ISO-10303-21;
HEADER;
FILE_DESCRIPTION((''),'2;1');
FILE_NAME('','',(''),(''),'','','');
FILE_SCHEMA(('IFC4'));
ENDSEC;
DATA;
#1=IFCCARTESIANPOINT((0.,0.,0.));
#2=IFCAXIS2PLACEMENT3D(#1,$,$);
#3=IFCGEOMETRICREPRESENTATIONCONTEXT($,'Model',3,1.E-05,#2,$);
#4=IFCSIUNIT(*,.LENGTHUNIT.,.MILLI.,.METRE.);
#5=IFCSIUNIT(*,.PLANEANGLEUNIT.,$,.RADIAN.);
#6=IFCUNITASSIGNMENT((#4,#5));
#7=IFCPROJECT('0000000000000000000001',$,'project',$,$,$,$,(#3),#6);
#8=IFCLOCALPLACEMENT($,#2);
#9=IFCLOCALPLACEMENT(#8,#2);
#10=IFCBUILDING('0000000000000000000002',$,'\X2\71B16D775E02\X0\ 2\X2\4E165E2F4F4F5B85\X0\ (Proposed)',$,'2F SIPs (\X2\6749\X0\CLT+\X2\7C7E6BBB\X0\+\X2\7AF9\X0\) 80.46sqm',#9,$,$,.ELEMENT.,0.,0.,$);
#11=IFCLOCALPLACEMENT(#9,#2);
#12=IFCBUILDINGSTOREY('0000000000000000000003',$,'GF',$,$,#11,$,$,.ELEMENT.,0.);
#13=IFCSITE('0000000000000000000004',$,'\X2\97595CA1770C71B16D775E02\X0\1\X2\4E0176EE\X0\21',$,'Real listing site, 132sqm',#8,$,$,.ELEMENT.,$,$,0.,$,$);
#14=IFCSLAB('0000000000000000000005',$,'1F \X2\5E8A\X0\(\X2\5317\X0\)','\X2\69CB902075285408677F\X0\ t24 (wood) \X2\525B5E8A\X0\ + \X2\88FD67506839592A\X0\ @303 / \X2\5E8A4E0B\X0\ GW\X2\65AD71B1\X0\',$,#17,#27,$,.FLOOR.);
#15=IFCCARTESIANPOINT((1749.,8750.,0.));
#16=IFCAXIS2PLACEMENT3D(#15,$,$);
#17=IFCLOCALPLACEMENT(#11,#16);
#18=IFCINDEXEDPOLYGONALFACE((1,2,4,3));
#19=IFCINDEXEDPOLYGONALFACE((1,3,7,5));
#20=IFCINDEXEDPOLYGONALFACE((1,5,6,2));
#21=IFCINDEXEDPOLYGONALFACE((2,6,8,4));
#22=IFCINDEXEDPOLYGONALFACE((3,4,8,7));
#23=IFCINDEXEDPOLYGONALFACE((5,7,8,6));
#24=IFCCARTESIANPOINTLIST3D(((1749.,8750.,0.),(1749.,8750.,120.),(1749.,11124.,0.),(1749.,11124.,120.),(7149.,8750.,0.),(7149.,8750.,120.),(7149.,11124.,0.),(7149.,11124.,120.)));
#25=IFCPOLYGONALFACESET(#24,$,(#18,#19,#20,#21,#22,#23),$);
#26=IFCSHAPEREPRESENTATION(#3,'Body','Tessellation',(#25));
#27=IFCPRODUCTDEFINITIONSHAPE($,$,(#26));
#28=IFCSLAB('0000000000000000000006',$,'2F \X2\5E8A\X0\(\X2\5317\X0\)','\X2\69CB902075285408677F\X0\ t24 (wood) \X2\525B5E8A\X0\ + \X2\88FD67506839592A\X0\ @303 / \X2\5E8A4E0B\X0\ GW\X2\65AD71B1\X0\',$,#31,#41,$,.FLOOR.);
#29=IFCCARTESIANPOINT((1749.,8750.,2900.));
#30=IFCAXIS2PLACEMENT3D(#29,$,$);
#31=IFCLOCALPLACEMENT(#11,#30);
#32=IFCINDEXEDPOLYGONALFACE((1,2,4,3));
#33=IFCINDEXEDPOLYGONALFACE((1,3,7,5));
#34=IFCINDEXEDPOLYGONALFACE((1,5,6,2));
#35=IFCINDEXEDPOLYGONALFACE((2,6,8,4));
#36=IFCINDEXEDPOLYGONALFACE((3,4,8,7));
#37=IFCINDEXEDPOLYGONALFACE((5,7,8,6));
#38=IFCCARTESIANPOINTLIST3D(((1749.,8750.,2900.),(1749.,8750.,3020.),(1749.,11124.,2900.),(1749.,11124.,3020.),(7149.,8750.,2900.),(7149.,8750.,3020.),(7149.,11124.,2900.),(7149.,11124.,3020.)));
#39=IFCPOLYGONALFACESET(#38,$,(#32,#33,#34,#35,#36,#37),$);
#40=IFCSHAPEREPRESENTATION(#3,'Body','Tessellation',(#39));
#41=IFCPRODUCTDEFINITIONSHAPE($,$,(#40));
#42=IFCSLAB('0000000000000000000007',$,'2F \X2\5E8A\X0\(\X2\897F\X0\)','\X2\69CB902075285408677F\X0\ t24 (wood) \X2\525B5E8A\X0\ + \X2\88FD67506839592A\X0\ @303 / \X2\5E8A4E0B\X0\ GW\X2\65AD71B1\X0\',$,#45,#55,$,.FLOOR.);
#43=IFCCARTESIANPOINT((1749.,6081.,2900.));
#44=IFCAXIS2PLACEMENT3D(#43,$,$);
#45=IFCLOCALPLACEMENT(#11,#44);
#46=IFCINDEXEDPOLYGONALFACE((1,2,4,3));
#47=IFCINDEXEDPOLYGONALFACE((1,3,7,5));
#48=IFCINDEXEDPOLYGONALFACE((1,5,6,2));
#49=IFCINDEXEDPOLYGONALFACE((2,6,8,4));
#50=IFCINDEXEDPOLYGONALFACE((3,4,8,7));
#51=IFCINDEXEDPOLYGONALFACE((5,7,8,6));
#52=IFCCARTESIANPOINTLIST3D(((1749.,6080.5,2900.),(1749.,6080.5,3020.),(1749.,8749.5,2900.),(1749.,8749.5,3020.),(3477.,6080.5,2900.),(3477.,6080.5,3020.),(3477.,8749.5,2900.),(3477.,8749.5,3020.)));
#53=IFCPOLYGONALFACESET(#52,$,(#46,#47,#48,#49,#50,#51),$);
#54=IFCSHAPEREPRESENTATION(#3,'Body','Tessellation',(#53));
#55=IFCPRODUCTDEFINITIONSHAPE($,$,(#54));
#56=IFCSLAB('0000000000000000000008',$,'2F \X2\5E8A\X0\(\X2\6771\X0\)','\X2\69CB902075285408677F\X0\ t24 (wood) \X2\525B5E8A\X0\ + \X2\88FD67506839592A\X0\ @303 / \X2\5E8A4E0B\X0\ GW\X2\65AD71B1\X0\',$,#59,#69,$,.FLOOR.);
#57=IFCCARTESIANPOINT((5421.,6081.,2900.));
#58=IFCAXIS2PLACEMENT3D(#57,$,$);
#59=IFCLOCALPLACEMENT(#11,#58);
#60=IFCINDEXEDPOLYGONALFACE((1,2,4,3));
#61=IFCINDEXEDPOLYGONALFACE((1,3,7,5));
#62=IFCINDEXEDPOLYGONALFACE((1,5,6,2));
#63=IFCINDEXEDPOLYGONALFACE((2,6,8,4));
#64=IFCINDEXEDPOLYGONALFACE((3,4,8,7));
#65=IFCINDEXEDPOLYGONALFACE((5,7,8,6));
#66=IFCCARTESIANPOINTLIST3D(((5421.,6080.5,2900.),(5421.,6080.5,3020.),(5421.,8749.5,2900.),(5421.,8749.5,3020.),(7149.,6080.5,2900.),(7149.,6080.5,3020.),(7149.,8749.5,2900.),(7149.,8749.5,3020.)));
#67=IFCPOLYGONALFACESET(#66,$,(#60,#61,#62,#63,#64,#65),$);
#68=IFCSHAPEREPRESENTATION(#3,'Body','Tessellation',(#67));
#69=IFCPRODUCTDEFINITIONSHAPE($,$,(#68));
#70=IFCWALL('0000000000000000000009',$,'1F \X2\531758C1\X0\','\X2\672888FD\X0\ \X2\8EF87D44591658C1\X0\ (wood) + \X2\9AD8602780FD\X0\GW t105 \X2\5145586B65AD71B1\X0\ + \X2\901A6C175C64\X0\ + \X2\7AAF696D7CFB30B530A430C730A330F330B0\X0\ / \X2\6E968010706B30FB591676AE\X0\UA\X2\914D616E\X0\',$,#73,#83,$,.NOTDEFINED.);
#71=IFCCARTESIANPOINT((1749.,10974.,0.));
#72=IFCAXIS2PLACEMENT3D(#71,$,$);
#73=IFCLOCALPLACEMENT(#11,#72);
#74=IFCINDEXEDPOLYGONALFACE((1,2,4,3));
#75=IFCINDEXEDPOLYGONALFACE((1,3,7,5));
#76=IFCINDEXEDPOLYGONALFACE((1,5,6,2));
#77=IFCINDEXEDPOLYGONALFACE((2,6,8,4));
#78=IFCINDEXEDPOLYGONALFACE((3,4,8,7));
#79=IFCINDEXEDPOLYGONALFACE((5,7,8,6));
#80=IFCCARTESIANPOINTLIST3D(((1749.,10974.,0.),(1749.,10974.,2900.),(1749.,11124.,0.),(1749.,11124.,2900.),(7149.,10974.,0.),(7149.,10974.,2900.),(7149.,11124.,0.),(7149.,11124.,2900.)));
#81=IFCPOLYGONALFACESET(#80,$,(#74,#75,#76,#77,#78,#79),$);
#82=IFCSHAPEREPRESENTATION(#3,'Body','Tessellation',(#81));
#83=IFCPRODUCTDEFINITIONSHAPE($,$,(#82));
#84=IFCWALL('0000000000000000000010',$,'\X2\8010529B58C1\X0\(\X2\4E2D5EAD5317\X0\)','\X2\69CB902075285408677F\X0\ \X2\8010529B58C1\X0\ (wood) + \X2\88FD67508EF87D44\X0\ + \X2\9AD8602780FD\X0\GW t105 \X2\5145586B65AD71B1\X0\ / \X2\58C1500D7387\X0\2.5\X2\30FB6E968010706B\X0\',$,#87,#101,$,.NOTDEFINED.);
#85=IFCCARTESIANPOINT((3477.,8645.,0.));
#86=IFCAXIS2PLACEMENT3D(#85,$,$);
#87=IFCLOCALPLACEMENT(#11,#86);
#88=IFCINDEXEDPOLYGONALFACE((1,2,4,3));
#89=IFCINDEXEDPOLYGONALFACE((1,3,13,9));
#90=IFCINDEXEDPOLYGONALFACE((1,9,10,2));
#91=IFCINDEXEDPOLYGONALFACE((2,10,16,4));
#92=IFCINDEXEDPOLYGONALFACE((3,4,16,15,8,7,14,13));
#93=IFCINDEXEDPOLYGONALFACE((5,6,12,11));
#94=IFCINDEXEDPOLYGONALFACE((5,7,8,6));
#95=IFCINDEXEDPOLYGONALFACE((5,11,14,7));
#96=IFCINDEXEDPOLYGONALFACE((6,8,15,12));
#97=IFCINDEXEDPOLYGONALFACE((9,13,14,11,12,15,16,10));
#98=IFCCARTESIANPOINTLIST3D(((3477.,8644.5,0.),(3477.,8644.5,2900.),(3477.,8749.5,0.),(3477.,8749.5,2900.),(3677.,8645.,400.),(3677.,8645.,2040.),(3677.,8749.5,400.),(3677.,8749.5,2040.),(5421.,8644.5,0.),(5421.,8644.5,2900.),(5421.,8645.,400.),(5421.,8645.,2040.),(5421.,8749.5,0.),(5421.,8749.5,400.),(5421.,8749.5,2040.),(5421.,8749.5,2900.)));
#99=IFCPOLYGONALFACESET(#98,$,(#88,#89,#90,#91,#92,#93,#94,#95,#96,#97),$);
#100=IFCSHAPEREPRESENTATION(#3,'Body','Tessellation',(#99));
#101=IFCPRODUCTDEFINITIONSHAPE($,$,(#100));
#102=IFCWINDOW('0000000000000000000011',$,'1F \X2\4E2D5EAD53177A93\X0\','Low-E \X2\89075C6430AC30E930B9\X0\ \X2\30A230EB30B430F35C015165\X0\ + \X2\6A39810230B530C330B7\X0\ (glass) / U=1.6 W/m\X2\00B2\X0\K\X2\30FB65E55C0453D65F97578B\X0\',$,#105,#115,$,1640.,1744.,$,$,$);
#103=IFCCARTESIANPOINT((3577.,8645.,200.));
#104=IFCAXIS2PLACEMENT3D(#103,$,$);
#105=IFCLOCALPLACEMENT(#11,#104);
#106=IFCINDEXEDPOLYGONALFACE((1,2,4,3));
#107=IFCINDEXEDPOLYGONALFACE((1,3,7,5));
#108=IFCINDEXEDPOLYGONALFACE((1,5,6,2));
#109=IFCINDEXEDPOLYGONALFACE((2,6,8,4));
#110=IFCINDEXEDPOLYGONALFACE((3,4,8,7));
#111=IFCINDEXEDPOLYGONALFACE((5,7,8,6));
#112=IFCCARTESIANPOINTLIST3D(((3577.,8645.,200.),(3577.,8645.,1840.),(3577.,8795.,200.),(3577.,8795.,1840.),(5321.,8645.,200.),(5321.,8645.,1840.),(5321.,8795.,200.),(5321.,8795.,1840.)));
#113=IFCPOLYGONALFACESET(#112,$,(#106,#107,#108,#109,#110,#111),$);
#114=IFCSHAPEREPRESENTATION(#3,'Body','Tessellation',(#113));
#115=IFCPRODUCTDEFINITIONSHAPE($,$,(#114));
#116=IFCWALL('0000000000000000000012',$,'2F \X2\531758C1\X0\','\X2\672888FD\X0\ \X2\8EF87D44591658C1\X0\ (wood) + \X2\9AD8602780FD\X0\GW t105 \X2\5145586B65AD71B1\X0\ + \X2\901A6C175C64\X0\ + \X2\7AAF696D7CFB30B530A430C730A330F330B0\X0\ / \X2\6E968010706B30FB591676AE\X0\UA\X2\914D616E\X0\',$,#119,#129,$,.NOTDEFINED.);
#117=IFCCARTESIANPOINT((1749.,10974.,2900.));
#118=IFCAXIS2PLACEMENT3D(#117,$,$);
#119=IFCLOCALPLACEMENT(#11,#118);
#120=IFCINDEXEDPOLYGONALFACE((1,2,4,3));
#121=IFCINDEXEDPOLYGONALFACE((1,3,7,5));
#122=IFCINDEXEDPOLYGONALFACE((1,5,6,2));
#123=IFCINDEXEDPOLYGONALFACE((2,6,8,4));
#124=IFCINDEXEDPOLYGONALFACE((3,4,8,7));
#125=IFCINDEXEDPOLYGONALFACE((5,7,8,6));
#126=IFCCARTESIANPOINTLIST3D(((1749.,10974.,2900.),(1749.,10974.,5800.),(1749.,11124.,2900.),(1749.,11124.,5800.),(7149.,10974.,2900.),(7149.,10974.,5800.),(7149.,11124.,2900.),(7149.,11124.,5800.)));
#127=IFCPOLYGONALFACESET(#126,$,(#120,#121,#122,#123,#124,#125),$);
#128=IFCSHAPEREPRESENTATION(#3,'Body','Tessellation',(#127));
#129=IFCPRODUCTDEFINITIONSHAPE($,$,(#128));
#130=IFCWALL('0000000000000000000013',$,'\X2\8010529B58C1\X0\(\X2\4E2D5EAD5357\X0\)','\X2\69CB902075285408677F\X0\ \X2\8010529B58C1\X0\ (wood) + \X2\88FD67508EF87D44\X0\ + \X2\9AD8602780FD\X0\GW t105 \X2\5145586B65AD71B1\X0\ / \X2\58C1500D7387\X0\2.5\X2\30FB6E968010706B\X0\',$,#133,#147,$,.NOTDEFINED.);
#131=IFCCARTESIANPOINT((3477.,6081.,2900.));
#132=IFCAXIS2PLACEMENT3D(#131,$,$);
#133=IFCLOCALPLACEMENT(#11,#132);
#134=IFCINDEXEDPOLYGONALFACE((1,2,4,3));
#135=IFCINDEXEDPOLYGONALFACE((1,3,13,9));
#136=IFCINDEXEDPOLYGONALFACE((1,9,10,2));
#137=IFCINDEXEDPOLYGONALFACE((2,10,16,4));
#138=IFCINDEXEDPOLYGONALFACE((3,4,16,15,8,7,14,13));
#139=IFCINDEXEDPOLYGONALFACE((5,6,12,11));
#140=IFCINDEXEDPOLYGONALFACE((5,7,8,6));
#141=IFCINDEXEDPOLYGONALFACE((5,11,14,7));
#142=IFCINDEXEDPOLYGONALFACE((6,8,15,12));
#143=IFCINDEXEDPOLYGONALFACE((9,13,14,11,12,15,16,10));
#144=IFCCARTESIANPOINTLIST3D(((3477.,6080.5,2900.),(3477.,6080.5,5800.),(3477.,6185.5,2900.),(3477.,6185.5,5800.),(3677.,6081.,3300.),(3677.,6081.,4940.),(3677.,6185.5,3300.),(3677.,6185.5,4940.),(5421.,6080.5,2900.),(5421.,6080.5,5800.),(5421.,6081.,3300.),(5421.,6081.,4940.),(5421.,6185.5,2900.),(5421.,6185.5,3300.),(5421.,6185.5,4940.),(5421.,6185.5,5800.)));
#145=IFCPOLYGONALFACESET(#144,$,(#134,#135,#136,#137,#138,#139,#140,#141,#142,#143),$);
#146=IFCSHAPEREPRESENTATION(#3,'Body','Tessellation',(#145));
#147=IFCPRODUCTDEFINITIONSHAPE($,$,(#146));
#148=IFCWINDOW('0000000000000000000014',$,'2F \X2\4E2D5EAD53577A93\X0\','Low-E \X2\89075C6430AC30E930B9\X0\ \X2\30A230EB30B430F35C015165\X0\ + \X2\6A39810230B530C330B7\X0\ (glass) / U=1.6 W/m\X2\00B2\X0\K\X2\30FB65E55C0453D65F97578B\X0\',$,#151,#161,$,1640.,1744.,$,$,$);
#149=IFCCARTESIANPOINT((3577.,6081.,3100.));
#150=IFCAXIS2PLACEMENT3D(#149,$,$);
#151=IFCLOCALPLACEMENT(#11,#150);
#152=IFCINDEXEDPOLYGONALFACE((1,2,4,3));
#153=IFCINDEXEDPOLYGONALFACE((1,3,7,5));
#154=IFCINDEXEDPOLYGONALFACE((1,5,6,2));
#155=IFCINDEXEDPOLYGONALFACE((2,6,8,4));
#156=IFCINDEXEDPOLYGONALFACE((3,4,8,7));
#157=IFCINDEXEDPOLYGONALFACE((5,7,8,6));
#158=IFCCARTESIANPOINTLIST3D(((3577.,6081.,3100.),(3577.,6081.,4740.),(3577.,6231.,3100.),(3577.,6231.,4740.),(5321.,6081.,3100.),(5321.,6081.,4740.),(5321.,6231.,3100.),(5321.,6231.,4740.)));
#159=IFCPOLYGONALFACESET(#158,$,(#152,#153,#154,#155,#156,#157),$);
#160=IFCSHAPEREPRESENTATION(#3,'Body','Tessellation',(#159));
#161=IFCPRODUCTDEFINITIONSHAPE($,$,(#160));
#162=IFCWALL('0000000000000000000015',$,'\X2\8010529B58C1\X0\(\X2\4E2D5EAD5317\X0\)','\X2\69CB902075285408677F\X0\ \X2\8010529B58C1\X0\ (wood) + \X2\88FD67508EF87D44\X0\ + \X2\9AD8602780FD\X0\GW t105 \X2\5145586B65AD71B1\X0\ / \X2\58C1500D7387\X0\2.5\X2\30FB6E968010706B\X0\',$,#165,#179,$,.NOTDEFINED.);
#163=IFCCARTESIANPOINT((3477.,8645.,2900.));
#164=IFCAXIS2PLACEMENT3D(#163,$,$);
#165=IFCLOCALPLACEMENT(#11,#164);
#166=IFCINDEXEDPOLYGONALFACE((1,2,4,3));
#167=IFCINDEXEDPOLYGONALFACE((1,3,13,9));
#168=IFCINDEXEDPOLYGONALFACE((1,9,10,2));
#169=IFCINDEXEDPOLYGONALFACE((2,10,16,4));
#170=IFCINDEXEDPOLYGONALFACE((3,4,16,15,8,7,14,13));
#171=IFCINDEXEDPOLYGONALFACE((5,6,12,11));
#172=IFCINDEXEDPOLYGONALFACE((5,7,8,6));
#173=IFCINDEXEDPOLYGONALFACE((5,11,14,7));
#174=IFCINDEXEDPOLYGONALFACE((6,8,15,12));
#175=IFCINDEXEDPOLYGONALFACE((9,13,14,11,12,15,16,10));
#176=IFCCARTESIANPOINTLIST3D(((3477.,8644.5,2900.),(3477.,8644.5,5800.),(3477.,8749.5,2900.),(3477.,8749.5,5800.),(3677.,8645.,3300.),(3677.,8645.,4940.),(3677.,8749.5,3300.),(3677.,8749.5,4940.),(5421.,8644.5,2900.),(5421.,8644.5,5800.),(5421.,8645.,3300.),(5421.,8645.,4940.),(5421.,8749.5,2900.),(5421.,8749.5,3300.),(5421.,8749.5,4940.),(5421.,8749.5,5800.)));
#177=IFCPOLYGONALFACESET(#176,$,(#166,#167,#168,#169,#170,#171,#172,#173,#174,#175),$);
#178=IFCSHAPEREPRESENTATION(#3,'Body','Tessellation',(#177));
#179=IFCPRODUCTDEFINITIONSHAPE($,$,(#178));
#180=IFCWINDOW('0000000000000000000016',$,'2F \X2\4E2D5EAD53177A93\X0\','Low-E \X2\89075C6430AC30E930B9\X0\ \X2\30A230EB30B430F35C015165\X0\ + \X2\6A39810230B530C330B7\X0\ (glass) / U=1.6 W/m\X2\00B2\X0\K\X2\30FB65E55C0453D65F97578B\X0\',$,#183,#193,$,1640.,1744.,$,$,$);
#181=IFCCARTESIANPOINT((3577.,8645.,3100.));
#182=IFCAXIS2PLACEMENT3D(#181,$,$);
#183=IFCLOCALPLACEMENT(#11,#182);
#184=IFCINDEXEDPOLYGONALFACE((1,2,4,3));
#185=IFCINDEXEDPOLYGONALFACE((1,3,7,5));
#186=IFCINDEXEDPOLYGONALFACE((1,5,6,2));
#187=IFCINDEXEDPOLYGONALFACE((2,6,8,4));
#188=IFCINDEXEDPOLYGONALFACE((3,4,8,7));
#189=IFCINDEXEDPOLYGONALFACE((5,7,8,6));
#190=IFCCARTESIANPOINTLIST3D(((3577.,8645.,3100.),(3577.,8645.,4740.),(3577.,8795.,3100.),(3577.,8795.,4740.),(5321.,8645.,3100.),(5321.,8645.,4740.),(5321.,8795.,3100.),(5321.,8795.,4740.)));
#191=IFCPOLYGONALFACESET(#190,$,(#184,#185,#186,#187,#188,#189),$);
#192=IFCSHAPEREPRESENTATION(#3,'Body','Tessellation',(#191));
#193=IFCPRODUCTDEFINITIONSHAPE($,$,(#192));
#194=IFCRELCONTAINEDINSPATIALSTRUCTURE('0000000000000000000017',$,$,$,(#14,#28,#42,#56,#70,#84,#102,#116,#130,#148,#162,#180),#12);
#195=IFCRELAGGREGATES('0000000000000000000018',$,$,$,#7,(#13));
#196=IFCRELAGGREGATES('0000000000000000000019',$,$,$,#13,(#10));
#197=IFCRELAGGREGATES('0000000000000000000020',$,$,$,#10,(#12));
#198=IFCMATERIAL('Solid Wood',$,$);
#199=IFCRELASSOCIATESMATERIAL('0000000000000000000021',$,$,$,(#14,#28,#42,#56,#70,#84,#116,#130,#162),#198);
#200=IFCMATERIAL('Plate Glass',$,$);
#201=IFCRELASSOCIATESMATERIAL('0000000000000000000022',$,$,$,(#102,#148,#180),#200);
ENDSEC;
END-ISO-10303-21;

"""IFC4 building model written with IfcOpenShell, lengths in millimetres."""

from ifc_helpers import new_model, si_unit, frame, frame_2d, origin, place, context, project, spatial, rectangle, extrude, material, element, fill, save


model = new_model("IFC4")

# Units and contexts
model_context = context("Model", 3, precision=1e-05, world=origin())
ifc_project = project(units=[si_unit("LENGTHUNIT", "METRE", prefix="MILLI"), si_unit("PLANEANGLEUNIT", "RADIAN")], contexts=[model_context])

# Site, building, storey
site_placement = place(None, origin())
site = spatial("IfcSite", under=ifc_project, at=site_placement, Name="静岡県熱海市1丁目21", ObjectType="Real listing site, 132sqm", CompositionType="ELEMENT", RefElevation=0.0)
building_placement = place(site_placement, origin())
building = spatial("IfcBuilding", under=site, at=building_placement, Name="熱海市 2世帯住宅 (Proposed)", ObjectType="2F SIPs (杉CLT+籾殻+竹) 80.46sqm", CompositionType="ELEMENT", ElevationOfRefHeight=0.0, ElevationOfTerrain=0.0)
storey_placement = place(building_placement, origin())
storey = spatial("IfcBuildingStorey", under=building, at=storey_placement, Name="GF", CompositionType="ELEMENT", Elevation=0.0)

# Slabs
ifc_material_1 = material(Name="Solid Wood")
slab_1_placement = place(storey_placement, frame((1749.0, 8750.0, 0.0)))
element("IfcSlab", 1, at=slab_1_placement, inside=storey, material=ifc_material_1, Name="1F 床(北)", Description="構造用合板 t24 (wood) 剛床 + 製材根太 @303 / 床下 GW断熱", PredefinedType="FLOOR", context=model_context, shape_type="SweptSolid", body=[
    extrude(rectangle(XDim=5400.0, YDim=2374.0, at=frame_2d((2700.0, 1187.0))), frame((1749.0, 8750.0, 0.0)), (0.0, 0.0, 1.0), 120.0),
])
slab_2_placement = place(storey_placement, frame((1749.0, 8750.0, 2900.0)))
element("IfcSlab", 2, at=slab_2_placement, inside=storey, material=ifc_material_1, Name="2F 床(北)", Description="構造用合板 t24 (wood) 剛床 + 製材根太 @303 / 床下 GW断熱", PredefinedType="FLOOR", context=model_context, shape_type="SweptSolid", body=[
    extrude(rectangle(XDim=5400.0, YDim=2374.0, at=frame_2d((2700.0, 1187.0))), frame((1749.0, 8750.0, 2900.0)), (0.0, 0.0, 1.0), 120.0),
])
slab_3_placement = place(storey_placement, frame((1749.0, 6081.0, 2900.0)))
element("IfcSlab", 3, at=slab_3_placement, inside=storey, material=ifc_material_1, Name="2F 床(西)", Description="構造用合板 t24 (wood) 剛床 + 製材根太 @303 / 床下 GW断熱", PredefinedType="FLOOR", context=model_context, shape_type="SweptSolid", body=[
    extrude(rectangle(XDim=1728.0, YDim=2669.0, at=frame_2d((864.0, 1334.0))), frame((1749.0, 6081.0, 2900.0)), (0.0, 0.0, 1.0), 120.0),
])
slab_4_placement = place(storey_placement, frame((5421.0, 6081.0, 2900.0)))
element("IfcSlab", 4, at=slab_4_placement, inside=storey, material=ifc_material_1, Name="2F 床(東)", Description="構造用合板 t24 (wood) 剛床 + 製材根太 @303 / 床下 GW断熱", PredefinedType="FLOOR", context=model_context, shape_type="SweptSolid", body=[
    extrude(rectangle(XDim=1728.0, YDim=2669.0, at=frame_2d((864.0, 1334.0))), frame((5421.0, 6081.0, 2900.0)), (0.0, 0.0, 1.0), 120.0),
])

# Wall
wall_1_placement = place(storey_placement, frame((1749.0, 10974.0, 0.0)))
element("IfcWall", 5, at=wall_1_placement, inside=storey, material=ifc_material_1, Name="1F 北壁", Description="木製 軸組外壁 (wood) + 高性能GW t105 充填断熱 + 通気層 + 窯業系サイディング / 準耐火・外皮UA配慮", PredefinedType="NOTDEFINED", context=model_context, shape_type="SweptSolid", body=[
    extrude(rectangle(XDim=5400.0, YDim=150.0, at=frame_2d((2700.0, 75.0))), frame((1749.0, 10974.0, 0.0)), (0.0, 0.0, 1.0), 2900.0),
])

# Wall, opening, window
wall_2_placement = place(storey_placement, frame((3477.0, 8645.0, 0.0)))
wall_2 = element("IfcWall", 6, at=wall_2_placement, inside=storey, material=ifc_material_1, Name="耐力壁(中庭北)", Description="構造用合板 耐力壁 (wood) + 製材軸組 + 高性能GW t105 充填断熱 / 壁倍率2.5・準耐火", PredefinedType="NOTDEFINED", context=model_context, shape_type="SweptSolid", body=[
    extrude(rectangle(XDim=1944.0, YDim=105.0, at=frame_2d((972.0, 52.0))), frame((3477.0, 8645.0, 0.0)), (0.0, 0.0, 1.0), 2900.0),
])
opening_1_placement = place(storey_placement, frame((3577.0, 8645.0, 200.0)))
opening_1 = element("IfcOpeningElement", 7, at=opening_1_placement, cuts=wall_2, PredefinedType="NOTDEFINED", context=model_context, shape_type="SweptSolid", body=[
    extrude(rectangle(XDim=1744.0, YDim=150.0, at=frame_2d((872.0, 75.0))), frame((3577.0, 8645.0, 200.0)), (0.0, 0.0, 1.0), 1640.0),
])
ifc_material_2 = material(Name="Plate Glass")
window_1_placement = place(storey_placement, frame((3577.0, 8645.0, 200.0)))
window_1 = element("IfcWindow", 8, at=window_1_placement, inside=storey, material=ifc_material_2, Name="1F 中庭北窓", Description="Low-E 複層ガラス アルゴン封入 + 樹脂サッシ (glass) / U=1.6 W/m²K・日射取得型", OverallHeight=1640.0, OverallWidth=1744.0, context=model_context, shape_type="SweptSolid", body=[
    extrude(rectangle(XDim=1744.0, YDim=150.0, at=frame_2d((872.0, 75.0))), frame((3577.0, 8645.0, 200.0)), (0.0, 0.0, 1.0), 1640.0),
])
fill(opening_1, window_1)

# Wall
wall_3_placement = place(storey_placement, frame((1749.0, 10974.0, 2900.0)))
element("IfcWall", 9, at=wall_3_placement, inside=storey, material=ifc_material_1, Name="2F 北壁", Description="木製 軸組外壁 (wood) + 高性能GW t105 充填断熱 + 通気層 + 窯業系サイディング / 準耐火・外皮UA配慮", PredefinedType="NOTDEFINED", context=model_context, shape_type="SweptSolid", body=[
    extrude(rectangle(XDim=5400.0, YDim=150.0, at=frame_2d((2700.0, 75.0))), frame((1749.0, 10974.0, 2900.0)), (0.0, 0.0, 1.0), 2900.0),
])

# Walls, openings, windows
wall_4_placement = place(storey_placement, frame((3477.0, 6081.0, 2900.0)))
wall_4 = element("IfcWall", 10, at=wall_4_placement, inside=storey, material=ifc_material_1, Name="耐力壁(中庭南)", Description="構造用合板 耐力壁 (wood) + 製材軸組 + 高性能GW t105 充填断熱 / 壁倍率2.5・準耐火", PredefinedType="NOTDEFINED", context=model_context, shape_type="SweptSolid", body=[
    extrude(rectangle(XDim=1944.0, YDim=105.0, at=frame_2d((972.0, 52.0))), frame((3477.0, 6081.0, 2900.0)), (0.0, 0.0, 1.0), 2900.0),
])
opening_2_placement = place(storey_placement, frame((3577.0, 6081.0, 3100.0)))
opening_2 = element("IfcOpeningElement", 11, at=opening_2_placement, cuts=wall_4, PredefinedType="NOTDEFINED", context=model_context, shape_type="SweptSolid", body=[
    extrude(rectangle(XDim=1744.0, YDim=150.0, at=frame_2d((872.0, 75.0))), frame((3577.0, 6081.0, 3100.0)), (0.0, 0.0, 1.0), 1640.0),
])
window_2_placement = place(storey_placement, frame((3577.0, 6081.0, 3100.0)))
window_2 = element("IfcWindow", 12, at=window_2_placement, inside=storey, material=ifc_material_2, Name="2F 中庭南窓", Description="Low-E 複層ガラス アルゴン封入 + 樹脂サッシ (glass) / U=1.6 W/m²K・日射取得型", OverallHeight=1640.0, OverallWidth=1744.0, context=model_context, shape_type="SweptSolid", body=[
    extrude(rectangle(XDim=1744.0, YDim=150.0, at=frame_2d((872.0, 75.0))), frame((3577.0, 6081.0, 3100.0)), (0.0, 0.0, 1.0), 1640.0),
])
fill(opening_2, window_2)
wall_5_placement = place(storey_placement, frame((3477.0, 8645.0, 2900.0)))
wall_5 = element("IfcWall", 13, at=wall_5_placement, inside=storey, material=ifc_material_1, Name="耐力壁(中庭北)", Description="構造用合板 耐力壁 (wood) + 製材軸組 + 高性能GW t105 充填断熱 / 壁倍率2.5・準耐火", PredefinedType="NOTDEFINED", context=model_context, shape_type="SweptSolid", body=[
    extrude(rectangle(XDim=1944.0, YDim=105.0, at=frame_2d((972.0, 52.0))), frame((3477.0, 8645.0, 2900.0)), (0.0, 0.0, 1.0), 2900.0),
])
opening_3_placement = place(storey_placement, frame((3577.0, 8645.0, 3100.0)))
opening_3 = element("IfcOpeningElement", 14, at=opening_3_placement, cuts=wall_5, PredefinedType="NOTDEFINED", context=model_context, shape_type="SweptSolid", body=[
    extrude(rectangle(XDim=1744.0, YDim=150.0, at=frame_2d((872.0, 75.0))), frame((3577.0, 8645.0, 3100.0)), (0.0, 0.0, 1.0), 1640.0),
])
window_3_placement = place(storey_placement, frame((3577.0, 8645.0, 3100.0)))
window_3 = element("IfcWindow", 15, at=window_3_placement, inside=storey, material=ifc_material_2, Name="2F 中庭北窓", Description="Low-E 複層ガラス アルゴン封入 + 樹脂サッシ (glass) / U=1.6 W/m²K・日射取得型", OverallHeight=1640.0, OverallWidth=1744.0, context=model_context, shape_type="SweptSolid", body=[
    extrude(rectangle(XDim=1744.0, YDim=150.0, at=frame_2d((872.0, 75.0))), frame((3577.0, 8645.0, 3100.0)), (0.0, 0.0, 1.0), 1640.0),
])
fill(opening_3, window_3)

save(model, "model.ifc")
